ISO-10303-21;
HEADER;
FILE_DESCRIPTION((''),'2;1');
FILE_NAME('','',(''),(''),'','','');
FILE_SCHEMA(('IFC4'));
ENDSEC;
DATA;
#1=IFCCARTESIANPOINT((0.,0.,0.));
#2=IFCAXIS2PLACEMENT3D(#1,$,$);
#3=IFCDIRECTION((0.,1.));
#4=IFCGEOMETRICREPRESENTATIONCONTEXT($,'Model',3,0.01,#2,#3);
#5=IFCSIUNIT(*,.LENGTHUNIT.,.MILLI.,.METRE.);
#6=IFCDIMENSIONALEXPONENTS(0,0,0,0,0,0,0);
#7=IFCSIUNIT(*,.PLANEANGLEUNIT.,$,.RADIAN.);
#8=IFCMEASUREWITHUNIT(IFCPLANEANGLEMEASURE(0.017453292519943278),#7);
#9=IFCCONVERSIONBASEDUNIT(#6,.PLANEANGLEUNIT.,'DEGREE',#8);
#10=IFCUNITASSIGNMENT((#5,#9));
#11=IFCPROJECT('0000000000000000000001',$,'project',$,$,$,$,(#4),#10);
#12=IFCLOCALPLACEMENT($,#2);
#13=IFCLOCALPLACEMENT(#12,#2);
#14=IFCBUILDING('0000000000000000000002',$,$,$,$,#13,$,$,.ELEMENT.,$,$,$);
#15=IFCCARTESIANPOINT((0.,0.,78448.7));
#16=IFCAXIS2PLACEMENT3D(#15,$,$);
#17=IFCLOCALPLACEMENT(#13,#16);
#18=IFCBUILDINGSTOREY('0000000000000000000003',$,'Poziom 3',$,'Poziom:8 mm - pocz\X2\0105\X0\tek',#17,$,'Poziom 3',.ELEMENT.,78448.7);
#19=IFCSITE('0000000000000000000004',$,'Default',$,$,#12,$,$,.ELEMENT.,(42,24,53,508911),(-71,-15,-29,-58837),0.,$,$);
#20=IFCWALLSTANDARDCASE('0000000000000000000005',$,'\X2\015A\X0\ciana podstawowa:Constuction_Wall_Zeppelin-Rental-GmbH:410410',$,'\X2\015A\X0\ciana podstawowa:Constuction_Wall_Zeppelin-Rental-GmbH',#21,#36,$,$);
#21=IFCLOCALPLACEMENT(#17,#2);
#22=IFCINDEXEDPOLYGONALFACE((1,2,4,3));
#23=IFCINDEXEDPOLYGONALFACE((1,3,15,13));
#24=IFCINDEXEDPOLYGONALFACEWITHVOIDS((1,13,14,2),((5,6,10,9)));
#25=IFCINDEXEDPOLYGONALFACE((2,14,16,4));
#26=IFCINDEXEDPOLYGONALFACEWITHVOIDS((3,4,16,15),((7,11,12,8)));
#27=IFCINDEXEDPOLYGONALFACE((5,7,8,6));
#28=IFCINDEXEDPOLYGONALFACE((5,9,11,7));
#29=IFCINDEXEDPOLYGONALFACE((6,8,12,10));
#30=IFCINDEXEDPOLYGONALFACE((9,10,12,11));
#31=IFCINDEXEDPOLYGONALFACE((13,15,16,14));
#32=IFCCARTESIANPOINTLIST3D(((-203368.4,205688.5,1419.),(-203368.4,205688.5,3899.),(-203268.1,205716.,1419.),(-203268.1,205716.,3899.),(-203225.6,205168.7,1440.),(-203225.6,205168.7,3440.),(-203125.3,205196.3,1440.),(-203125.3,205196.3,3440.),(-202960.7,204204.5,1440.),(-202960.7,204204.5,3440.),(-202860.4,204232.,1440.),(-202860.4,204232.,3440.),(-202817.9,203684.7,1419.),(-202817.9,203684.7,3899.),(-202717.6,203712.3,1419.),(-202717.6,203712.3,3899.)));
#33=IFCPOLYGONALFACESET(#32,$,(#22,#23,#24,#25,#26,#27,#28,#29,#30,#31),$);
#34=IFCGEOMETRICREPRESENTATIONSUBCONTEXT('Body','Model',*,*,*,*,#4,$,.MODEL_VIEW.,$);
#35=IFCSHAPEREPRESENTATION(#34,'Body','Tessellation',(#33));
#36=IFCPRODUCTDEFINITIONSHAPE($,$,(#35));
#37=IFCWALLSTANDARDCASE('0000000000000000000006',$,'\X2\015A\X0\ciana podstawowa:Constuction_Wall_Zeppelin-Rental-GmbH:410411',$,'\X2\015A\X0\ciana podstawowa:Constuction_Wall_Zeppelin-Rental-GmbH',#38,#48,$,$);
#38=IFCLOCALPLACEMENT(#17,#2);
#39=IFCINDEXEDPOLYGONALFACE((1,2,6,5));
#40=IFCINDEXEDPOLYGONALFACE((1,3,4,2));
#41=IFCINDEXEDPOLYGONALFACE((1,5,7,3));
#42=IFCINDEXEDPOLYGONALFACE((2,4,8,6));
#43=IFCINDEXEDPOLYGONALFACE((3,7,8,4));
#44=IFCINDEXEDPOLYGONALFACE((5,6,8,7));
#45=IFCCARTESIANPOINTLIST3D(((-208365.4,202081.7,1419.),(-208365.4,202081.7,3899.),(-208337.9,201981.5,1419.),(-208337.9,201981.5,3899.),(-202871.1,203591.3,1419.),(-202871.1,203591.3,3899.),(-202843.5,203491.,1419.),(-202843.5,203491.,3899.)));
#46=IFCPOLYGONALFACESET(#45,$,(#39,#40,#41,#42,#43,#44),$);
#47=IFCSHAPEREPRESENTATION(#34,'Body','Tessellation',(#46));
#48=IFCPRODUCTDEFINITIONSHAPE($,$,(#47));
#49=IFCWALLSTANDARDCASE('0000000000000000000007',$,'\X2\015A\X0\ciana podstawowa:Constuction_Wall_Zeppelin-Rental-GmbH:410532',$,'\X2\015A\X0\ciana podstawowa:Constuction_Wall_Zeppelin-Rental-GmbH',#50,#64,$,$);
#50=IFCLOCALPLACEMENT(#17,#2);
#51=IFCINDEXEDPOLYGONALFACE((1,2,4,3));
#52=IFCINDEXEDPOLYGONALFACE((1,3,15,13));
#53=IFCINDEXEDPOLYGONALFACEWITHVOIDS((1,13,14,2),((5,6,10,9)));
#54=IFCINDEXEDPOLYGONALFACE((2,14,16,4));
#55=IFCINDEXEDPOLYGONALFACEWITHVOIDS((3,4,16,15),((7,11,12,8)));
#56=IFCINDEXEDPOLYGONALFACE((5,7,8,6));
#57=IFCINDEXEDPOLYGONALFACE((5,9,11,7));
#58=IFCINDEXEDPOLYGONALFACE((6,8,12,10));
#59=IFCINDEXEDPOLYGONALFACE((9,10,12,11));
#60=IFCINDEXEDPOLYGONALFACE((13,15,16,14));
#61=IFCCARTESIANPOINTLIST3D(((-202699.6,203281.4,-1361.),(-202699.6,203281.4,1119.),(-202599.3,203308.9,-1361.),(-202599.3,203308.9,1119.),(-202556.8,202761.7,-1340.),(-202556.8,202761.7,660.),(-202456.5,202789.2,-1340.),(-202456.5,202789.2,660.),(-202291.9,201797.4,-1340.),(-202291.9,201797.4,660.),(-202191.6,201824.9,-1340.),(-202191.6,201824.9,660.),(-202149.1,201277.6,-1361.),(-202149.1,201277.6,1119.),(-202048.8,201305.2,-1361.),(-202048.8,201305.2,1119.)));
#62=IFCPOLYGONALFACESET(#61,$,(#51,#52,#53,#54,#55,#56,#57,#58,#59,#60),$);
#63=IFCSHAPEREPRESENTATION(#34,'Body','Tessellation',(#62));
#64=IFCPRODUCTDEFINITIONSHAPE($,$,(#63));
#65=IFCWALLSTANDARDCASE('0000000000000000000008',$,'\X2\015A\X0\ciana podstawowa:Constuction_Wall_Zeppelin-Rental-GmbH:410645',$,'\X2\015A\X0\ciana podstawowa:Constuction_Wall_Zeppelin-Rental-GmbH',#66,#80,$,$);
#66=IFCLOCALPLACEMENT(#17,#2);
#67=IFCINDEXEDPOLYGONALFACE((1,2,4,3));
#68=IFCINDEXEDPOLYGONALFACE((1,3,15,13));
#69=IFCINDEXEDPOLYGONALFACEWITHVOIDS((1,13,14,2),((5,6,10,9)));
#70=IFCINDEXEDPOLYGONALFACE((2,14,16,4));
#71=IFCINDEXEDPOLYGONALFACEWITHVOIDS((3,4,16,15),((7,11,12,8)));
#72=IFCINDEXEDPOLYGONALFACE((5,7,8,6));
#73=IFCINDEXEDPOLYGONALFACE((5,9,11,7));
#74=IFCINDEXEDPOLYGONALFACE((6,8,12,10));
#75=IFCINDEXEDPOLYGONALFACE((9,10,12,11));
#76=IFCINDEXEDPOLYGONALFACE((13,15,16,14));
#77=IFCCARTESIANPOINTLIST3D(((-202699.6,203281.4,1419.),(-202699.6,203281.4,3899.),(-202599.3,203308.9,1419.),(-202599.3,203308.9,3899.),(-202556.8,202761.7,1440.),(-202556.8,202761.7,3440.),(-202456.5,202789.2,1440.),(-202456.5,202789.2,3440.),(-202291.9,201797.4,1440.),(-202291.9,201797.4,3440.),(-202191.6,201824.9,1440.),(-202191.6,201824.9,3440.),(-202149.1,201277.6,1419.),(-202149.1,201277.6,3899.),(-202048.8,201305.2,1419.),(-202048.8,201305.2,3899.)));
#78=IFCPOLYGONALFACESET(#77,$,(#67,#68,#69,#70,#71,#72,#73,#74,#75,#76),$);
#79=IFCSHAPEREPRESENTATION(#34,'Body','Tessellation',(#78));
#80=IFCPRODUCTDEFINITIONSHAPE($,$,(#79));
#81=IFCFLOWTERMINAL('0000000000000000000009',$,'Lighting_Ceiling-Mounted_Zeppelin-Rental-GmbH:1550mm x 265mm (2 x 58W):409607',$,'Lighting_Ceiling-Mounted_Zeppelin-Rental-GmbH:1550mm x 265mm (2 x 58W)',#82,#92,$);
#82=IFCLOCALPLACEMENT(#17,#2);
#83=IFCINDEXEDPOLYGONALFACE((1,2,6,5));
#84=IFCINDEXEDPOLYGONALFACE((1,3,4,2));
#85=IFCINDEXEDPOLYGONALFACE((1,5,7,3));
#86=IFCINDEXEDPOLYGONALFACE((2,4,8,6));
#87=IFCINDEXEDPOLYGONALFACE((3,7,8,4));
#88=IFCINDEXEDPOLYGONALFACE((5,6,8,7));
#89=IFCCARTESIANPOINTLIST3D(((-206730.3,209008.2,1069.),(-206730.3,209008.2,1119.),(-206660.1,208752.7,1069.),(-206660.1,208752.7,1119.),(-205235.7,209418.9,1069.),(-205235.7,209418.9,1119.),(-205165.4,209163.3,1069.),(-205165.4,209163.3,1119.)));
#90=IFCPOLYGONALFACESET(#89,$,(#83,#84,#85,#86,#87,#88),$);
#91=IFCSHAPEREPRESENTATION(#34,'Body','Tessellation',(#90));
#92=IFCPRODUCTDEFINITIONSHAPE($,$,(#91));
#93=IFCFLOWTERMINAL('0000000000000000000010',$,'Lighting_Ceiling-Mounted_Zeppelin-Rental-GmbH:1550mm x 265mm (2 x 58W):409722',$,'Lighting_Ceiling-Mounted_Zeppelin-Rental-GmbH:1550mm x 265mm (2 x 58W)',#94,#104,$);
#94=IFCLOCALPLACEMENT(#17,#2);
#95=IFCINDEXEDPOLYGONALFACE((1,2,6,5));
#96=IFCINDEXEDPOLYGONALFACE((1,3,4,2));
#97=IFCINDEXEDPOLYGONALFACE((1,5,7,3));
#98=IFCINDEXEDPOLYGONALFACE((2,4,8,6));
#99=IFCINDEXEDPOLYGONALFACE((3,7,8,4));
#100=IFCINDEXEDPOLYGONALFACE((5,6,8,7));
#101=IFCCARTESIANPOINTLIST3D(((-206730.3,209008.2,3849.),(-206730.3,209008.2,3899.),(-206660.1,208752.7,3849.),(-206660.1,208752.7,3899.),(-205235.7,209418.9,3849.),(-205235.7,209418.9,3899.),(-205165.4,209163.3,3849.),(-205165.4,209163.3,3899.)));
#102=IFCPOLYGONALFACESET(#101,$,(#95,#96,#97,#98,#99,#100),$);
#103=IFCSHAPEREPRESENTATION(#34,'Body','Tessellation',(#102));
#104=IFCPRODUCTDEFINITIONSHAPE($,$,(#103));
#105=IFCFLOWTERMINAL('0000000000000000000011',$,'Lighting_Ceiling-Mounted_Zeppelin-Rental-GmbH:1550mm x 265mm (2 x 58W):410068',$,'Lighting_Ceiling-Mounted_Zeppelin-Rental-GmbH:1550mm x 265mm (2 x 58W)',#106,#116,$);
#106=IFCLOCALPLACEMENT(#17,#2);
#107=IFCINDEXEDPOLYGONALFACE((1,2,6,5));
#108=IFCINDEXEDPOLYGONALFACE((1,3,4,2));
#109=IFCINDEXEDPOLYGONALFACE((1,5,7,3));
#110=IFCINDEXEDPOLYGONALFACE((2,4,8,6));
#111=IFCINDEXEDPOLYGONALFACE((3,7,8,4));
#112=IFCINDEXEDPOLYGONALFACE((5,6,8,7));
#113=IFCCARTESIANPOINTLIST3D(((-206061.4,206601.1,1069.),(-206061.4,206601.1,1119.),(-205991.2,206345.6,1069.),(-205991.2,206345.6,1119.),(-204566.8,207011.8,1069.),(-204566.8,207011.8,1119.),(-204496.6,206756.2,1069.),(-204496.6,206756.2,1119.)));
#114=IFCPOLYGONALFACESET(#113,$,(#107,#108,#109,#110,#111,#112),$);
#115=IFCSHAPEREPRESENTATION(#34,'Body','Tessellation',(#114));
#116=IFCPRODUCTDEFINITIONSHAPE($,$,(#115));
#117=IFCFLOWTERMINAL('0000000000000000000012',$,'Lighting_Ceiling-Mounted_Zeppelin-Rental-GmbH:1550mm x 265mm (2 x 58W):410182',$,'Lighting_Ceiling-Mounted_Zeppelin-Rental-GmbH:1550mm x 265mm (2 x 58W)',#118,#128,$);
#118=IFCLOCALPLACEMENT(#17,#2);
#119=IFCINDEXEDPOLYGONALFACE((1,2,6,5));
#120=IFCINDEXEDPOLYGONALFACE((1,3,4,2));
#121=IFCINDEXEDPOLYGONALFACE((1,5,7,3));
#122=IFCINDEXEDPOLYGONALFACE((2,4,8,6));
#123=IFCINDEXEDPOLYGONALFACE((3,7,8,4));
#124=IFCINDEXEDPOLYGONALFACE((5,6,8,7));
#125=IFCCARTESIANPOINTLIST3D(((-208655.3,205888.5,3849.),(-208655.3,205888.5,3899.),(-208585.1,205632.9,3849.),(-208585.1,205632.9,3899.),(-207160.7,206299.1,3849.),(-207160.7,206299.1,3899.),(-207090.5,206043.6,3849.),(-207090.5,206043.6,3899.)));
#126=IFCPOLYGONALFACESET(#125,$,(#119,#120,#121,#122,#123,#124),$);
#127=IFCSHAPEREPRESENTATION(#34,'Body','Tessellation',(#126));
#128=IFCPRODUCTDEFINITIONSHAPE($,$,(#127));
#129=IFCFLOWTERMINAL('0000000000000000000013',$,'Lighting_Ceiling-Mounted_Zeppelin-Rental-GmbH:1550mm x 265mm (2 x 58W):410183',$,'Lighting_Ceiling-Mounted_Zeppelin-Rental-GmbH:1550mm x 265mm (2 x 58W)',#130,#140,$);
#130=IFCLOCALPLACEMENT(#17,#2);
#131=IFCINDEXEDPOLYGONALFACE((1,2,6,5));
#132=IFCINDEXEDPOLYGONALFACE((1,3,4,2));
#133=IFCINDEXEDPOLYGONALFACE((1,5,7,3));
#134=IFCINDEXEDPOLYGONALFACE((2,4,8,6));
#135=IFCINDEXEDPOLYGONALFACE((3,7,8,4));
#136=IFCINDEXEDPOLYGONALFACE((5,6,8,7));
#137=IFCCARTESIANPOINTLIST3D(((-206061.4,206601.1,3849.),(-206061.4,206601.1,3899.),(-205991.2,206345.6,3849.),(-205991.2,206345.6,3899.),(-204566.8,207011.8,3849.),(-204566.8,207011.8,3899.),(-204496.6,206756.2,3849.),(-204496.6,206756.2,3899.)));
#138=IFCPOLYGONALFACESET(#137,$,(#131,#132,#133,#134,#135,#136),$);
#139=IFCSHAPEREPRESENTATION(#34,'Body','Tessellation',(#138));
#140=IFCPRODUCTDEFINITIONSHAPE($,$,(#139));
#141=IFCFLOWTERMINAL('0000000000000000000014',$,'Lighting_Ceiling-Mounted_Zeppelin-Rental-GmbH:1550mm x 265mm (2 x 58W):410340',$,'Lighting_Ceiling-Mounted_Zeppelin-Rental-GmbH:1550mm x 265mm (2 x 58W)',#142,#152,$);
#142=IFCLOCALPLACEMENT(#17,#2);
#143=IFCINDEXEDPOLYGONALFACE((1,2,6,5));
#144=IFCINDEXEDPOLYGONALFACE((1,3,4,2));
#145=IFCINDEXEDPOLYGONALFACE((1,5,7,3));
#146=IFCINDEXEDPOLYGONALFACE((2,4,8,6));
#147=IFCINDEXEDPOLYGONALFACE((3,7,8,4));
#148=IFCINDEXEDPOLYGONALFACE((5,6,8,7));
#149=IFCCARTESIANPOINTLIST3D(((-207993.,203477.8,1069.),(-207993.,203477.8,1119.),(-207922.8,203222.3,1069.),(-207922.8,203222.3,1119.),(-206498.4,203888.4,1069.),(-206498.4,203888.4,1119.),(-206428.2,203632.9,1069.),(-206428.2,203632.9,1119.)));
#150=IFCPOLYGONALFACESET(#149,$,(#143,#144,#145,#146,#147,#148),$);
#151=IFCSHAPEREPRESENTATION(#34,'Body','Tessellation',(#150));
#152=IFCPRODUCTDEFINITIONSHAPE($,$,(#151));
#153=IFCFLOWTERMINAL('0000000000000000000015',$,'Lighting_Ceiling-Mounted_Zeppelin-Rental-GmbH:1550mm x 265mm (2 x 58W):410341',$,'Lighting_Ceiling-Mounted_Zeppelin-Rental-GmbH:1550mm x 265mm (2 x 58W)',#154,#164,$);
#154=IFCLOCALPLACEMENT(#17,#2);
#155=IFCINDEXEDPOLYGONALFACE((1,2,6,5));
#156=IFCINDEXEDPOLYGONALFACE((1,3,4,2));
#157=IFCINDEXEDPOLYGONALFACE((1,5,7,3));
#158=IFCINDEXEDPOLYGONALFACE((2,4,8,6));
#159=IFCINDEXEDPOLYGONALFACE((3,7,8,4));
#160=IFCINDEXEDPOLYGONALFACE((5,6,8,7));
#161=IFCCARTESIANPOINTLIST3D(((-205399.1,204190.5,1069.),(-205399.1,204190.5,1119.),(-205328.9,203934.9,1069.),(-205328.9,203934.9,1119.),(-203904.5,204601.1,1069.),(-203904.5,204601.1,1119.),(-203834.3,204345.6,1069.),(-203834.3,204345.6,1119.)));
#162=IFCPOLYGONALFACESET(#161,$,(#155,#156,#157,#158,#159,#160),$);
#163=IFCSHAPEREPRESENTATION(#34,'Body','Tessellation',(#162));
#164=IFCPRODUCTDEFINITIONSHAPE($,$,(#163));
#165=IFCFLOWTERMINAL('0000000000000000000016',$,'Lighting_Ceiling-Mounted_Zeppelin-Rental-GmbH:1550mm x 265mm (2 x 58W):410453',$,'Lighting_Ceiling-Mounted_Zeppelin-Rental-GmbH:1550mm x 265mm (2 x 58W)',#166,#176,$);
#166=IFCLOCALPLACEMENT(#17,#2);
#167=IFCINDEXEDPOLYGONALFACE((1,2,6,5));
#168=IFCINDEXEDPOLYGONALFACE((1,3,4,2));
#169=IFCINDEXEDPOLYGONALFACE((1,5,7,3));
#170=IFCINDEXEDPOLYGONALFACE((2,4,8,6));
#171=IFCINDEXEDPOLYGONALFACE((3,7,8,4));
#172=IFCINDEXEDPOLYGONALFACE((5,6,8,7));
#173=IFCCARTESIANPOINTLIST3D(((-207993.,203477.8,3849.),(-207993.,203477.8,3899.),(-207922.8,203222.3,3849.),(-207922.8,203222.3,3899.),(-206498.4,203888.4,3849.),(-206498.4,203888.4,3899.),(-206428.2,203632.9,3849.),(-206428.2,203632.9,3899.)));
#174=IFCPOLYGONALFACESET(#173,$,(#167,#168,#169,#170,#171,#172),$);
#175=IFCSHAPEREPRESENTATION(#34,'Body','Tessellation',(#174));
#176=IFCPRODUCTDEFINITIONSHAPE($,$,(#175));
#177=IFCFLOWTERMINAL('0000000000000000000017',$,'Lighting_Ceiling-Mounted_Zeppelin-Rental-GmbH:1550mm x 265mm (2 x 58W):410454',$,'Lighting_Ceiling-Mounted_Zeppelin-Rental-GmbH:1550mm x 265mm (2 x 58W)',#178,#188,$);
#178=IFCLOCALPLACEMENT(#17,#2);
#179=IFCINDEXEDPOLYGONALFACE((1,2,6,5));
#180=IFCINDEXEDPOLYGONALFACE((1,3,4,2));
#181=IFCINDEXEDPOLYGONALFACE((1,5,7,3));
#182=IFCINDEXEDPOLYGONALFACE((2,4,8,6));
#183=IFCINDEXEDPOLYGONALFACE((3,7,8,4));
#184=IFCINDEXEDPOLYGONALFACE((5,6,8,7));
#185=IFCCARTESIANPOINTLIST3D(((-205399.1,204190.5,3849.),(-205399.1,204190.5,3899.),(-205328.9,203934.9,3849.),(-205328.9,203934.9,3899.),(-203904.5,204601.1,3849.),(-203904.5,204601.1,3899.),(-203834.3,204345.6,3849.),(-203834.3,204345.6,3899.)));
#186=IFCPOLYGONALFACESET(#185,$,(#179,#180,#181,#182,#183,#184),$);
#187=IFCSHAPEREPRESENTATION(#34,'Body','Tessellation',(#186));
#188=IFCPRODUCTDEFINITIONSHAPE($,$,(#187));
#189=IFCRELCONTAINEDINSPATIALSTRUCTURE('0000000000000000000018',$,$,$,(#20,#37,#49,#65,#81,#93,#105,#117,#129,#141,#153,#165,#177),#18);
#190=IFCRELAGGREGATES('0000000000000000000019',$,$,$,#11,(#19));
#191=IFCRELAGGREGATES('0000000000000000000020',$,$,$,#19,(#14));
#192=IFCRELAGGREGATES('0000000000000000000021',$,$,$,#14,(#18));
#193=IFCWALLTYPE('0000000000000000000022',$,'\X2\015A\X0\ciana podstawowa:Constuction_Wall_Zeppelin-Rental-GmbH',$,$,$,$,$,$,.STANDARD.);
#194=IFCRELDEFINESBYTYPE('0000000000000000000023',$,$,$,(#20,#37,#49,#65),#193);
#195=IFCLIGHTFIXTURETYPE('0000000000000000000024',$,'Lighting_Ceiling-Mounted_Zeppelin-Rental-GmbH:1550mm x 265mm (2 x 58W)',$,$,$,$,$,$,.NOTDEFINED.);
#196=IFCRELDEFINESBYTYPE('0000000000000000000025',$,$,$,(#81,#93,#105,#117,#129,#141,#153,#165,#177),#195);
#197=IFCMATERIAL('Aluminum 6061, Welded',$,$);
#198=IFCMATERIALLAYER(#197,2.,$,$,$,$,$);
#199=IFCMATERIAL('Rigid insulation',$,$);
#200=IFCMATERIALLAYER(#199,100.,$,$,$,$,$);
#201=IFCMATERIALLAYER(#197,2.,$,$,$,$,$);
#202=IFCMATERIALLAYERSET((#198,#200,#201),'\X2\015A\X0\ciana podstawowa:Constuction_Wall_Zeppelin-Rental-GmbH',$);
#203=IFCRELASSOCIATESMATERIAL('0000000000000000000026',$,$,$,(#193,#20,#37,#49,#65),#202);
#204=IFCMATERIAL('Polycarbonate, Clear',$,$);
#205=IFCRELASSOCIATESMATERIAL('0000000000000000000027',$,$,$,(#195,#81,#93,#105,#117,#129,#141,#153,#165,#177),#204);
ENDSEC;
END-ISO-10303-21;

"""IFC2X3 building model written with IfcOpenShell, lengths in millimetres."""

from ifc_helpers import new_model, entity, si_unit, converted_unit, direction, frame, frame_2d, origin, origin_2d_with_axis, place, context, subcontext, project, spatial, rectangle, extrude, source, transform, mapped, material, layer, layer_set, layer_usage, type_object, type_shapes, element, save


model = new_model("IFC2X3")

# Units and contexts
model_context = context("Model", 3, precision=0.01, world=origin(), true_north=direction((0.0, 1.0)))
body_context = subcontext(model_context, "Body", "Model", "MODEL_VIEW")
ifc_project = project(units=[si_unit("LENGTHUNIT", "METRE", prefix="MILLI"), converted_unit("PLANEANGLEUNIT", "DEGREE", entity("IfcPlaneAngleMeasure", 0.017453292519943278), si_unit("PLANEANGLEUNIT", "RADIAN"), dimensions=[0, 0, 0, 0, 0, 0, 0])], contexts=[model_context])

# Site, building, storey
site_placement = place(None, origin())
site = spatial("IfcSite", under=ifc_project, at=site_placement, Name="Default", CompositionType="ELEMENT", RefLatitude=(42, 24, 53, 508911), RefLongitude=(-71, -15, -29, -58837), RefElevation=0.0)
building_placement = place(site_placement, origin())
building = spatial("IfcBuilding", under=site, at=building_placement, CompositionType="ELEMENT")
storey_placement = place(building_placement, frame((0.0, 0.0, 78448.7)))
storey = spatial("IfcBuildingStorey", under=building, at=storey_placement, Name="Poziom 3", ObjectType="Poziom:8 mm - początek", LongName="Poziom 3", CompositionType="ELEMENT", Elevation=78448.7)

# Shared definitions
ifc_material_1 = material(Name="Aluminum 6061, Welded")
ifc_layer_1 = layer(ifc_material_1, 2.0)
ifc_material_2 = material(Name="Rigid insulation")
ifc_layer_2 = layer(ifc_material_2, 100.0)
ifc_layer_3 = layer(ifc_material_1, 2.0)
ifc_layer_set = layer_set([ifc_layer_1, ifc_layer_2, ifc_layer_3], Name="Ściana podstawowa:Constuction_Wall_Zeppelin-Rental-GmbH")
wall_type = type_object("IfcWallType", Name="Ściana podstawowa:Constuction_Wall_Zeppelin-Rental-GmbH", PredefinedType="STANDARD", material=ifc_layer_set)

# Wall, opening
ifc_layer_usage_1 = layer_usage(ifc_layer_set, "AXIS2", "NEGATIVE", 52.0)
wall_1_placement = place(storey_placement, frame((-203318.3, 205702.3, 1419.0), z_axis=(0.0, 0.0, 1.0), x_axis=(0.264931, -0.964267, 0.0)))
wall_1 = element("IfcWallStandardCase", 1, at=wall_1_placement, inside=storey, type_object=wall_type, material=ifc_layer_usage_1, Name="Ściana podstawowa:Constuction_Wall_Zeppelin-Rental-GmbH:410410", ObjectType="Ściana podstawowa:Constuction_Wall_Zeppelin-Rental-GmbH", context=body_context, shape_type="SweptSolid", body=[
    extrude(rectangle(XDim=2078.0, YDim=104.0, at=frame_2d((1039.0, 0.0), x_axis=(-1.0, 0.0))), origin(), (0.0, 0.0, 1.0), 2480.0),
])
opening_1_placement = place(wall_1_placement, frame((539.0, -52.0, 21.0)))
element("IfcOpeningElement", 2, at=opening_1_placement, cuts=wall_1, ObjectType="Opening", context=body_context, shape_type="SweptSolid", body=[
    extrude(rectangle(XDim=2000.0, YDim=1000.0, at=frame_2d((1000.0, 500.0), x_axis=(1.0, 0.0))), frame((0.0, 0.0, 0.0), z_axis=(0.0, 1.0, 0.0), x_axis=(0.0, 0.0, 1.0)), (0.0, 0.0, 1.0), 104.0),
])

# Wall
ifc_layer_usage_2 = layer_usage(ifc_layer_set, "AXIS2", "NEGATIVE", 52.0)
wall_2_placement = place(storey_placement, frame((-202857.3, 203541.2, 1419.0), z_axis=(0.0, 0.0, 1.0), x_axis=(-0.964267, -0.264931, 0.0)))
element("IfcWallStandardCase", 3, at=wall_2_placement, inside=storey, type_object=wall_type, material=ifc_layer_usage_2, Name="Ściana podstawowa:Constuction_Wall_Zeppelin-Rental-GmbH:410411", ObjectType="Ściana podstawowa:Constuction_Wall_Zeppelin-Rental-GmbH", context=body_context, shape_type="SweptSolid", body=[
    extrude(rectangle(XDim=5698.0, YDim=104.0, at=frame_2d((2849.0, 0.0), x_axis=(-1.0, 0.0))), origin(), (0.0, 0.0, 1.0), 2480.0),
])

# Walls, openings
ifc_layer_usage_3 = layer_usage(ifc_layer_set, "AXIS2", "NEGATIVE", 52.0)
wall_3_placement = place(storey_placement, frame((-202649.5, 203295.2, -1361.0), z_axis=(0.0, 0.0, 1.0), x_axis=(0.264931, -0.964267, 0.0)))
wall_3 = element("IfcWallStandardCase", 4, at=wall_3_placement, inside=storey, type_object=wall_type, material=ifc_layer_usage_3, Name="Ściana podstawowa:Constuction_Wall_Zeppelin-Rental-GmbH:410532", ObjectType="Ściana podstawowa:Constuction_Wall_Zeppelin-Rental-GmbH", context=body_context, shape_type="SweptSolid", body=[
    extrude(rectangle(XDim=2078.0, YDim=104.0, at=frame_2d((1039.0, 0.0), x_axis=(-1.0, 0.0))), origin(), (0.0, 0.0, 1.0), 2480.0),
])
opening_2_placement = place(wall_3_placement, frame((539.0, -52.0, 21.0)))
element("IfcOpeningElement", 5, at=opening_2_placement, cuts=wall_3, ObjectType="Opening", context=body_context, shape_type="SweptSolid", body=[
    extrude(rectangle(XDim=2000.0, YDim=1000.0, at=frame_2d((1000.0, 500.0), x_axis=(1.0, 0.0))), frame((0.0, 0.0, 0.0), z_axis=(0.0, 1.0, 0.0), x_axis=(0.0, 0.0, 1.0)), (0.0, 0.0, 1.0), 104.0),
])
ifc_layer_usage_4 = layer_usage(ifc_layer_set, "AXIS2", "NEGATIVE", 52.0)
wall_4_placement = place(storey_placement, frame((-202649.5, 203295.2, 1419.0), z_axis=(0.0, 0.0, 1.0), x_axis=(0.264931, -0.964267, 0.0)))
wall_4 = element("IfcWallStandardCase", 6, at=wall_4_placement, inside=storey, type_object=wall_type, material=ifc_layer_usage_4, Name="Ściana podstawowa:Constuction_Wall_Zeppelin-Rental-GmbH:410645", ObjectType="Ściana podstawowa:Constuction_Wall_Zeppelin-Rental-GmbH", context=body_context, shape_type="SweptSolid", body=[
    extrude(rectangle(XDim=2078.0, YDim=104.0, at=frame_2d((1039.0, 0.0), x_axis=(-1.0, 0.0))), origin(), (0.0, 0.0, 1.0), 2480.0),
])
opening_3_placement = place(wall_4_placement, frame((539.0, -52.0, 21.0)))
element("IfcOpeningElement", 7, at=opening_3_placement, cuts=wall_4, ObjectType="Opening", context=body_context, shape_type="SweptSolid", body=[
    extrude(rectangle(XDim=2000.0, YDim=1000.0, at=frame_2d((1000.0, 500.0), x_axis=(1.0, 0.0))), frame((0.0, 0.0, 0.0), z_axis=(0.0, 1.0, 0.0), x_axis=(0.0, 0.0, 1.0)), (0.0, 0.0, 1.0), 104.0),
])

# Flow terminals
ifc_material_3 = material(Name="Polycarbonate, Clear")
light_fixture_type = type_object("IfcLightFixtureType", Name="Lighting_Ceiling-Mounted_Zeppelin-Rental-GmbH:1550mm x 265mm (2 x 58W)", PredefinedType="NOTDEFINED", material=ifc_material_3)
shared_shape = source(origin(), body_context, "Body", "SweptSolid", [
    extrude(rectangle(XDim=1550.0, YDim=265.0, at=origin_2d_with_axis()), frame((0.0, 0.0, 0.0), z_axis=(0.0, 0.0, 1.0), x_axis=(-1.0, 0.0, 0.0)), (0.0, 0.0, 1.0), 50.0),
])
type_shapes(light_fixture_type, [shared_shape])
for number, where, z_axis, x_axis, name in (
    (8, (-205947.9, 209085.8, 1119.0), (0.0, 0.0, -1.0), (-0.964267, -0.264931, 0.0), "Lighting_Ceiling-Mounted_Zeppelin-Rental-GmbH:1550mm x 265mm (2 x 58W):409607"),
    (9, (-205947.9, 209085.8, 3899.0), (0.0, 0.0, -1.0), (-0.964267, -0.264931, 0.0), "Lighting_Ceiling-Mounted_Zeppelin-Rental-GmbH:1550mm x 265mm (2 x 58W):409722"),
    (10, (-205279.0, 206678.7, 1119.0), (0.0, 0.0, -1.0), (-0.964267, -0.264931, 0.0), "Lighting_Ceiling-Mounted_Zeppelin-Rental-GmbH:1550mm x 265mm (2 x 58W):410068"),
    (11, (-207872.9, 205966.0, 3899.0), (0.0, 0.0, -1.0), (-0.964267, -0.264931, 0.0), "Lighting_Ceiling-Mounted_Zeppelin-Rental-GmbH:1550mm x 265mm (2 x 58W):410182"),
    (12, (-205279.0, 206678.7, 3899.0), (0.0, 0.0, -1.0), (-0.964267, -0.264931, 0.0), "Lighting_Ceiling-Mounted_Zeppelin-Rental-GmbH:1550mm x 265mm (2 x 58W):410183"),
    (13, (-207210.6, 203555.4, 1119.0), (0.0, 0.0, -1.0), (-0.964267, -0.264931, 0.0), "Lighting_Ceiling-Mounted_Zeppelin-Rental-GmbH:1550mm x 265mm (2 x 58W):410340"),
    (14, (-204616.7, 204268.0, 1119.0), (0.0, 0.0, -1.0), (-0.964267, -0.264931, 0.0), "Lighting_Ceiling-Mounted_Zeppelin-Rental-GmbH:1550mm x 265mm (2 x 58W):410341"),
    (15, (-207210.6, 203555.4, 3899.0), (0.0, 0.0, -1.0), (-0.964267, -0.264931, 0.0), "Lighting_Ceiling-Mounted_Zeppelin-Rental-GmbH:1550mm x 265mm (2 x 58W):410453"),
    (16, (-204616.7, 204268.0, 3899.0), (0.0, 0.0, -1.0), (-0.964267, -0.264931, 0.0), "Lighting_Ceiling-Mounted_Zeppelin-Rental-GmbH:1550mm x 265mm (2 x 58W):410454"),
):
    element("IfcFlowTerminal", number, at=place(storey_placement, frame(where, z_axis=z_axis, x_axis=x_axis)), inside=storey, type_object=light_fixture_type, material=ifc_material_3, Name=name, ObjectType="Lighting_Ceiling-Mounted_Zeppelin-Rental-GmbH:1550mm x 265mm (2 x 58W)", context=body_context, shape_type="MappedRepresentation", body=[
        mapped(shared_shape, transform((0.0, 0.0, 0.0), scale=1.0)),
    ])

save(model, "model.ifc")
